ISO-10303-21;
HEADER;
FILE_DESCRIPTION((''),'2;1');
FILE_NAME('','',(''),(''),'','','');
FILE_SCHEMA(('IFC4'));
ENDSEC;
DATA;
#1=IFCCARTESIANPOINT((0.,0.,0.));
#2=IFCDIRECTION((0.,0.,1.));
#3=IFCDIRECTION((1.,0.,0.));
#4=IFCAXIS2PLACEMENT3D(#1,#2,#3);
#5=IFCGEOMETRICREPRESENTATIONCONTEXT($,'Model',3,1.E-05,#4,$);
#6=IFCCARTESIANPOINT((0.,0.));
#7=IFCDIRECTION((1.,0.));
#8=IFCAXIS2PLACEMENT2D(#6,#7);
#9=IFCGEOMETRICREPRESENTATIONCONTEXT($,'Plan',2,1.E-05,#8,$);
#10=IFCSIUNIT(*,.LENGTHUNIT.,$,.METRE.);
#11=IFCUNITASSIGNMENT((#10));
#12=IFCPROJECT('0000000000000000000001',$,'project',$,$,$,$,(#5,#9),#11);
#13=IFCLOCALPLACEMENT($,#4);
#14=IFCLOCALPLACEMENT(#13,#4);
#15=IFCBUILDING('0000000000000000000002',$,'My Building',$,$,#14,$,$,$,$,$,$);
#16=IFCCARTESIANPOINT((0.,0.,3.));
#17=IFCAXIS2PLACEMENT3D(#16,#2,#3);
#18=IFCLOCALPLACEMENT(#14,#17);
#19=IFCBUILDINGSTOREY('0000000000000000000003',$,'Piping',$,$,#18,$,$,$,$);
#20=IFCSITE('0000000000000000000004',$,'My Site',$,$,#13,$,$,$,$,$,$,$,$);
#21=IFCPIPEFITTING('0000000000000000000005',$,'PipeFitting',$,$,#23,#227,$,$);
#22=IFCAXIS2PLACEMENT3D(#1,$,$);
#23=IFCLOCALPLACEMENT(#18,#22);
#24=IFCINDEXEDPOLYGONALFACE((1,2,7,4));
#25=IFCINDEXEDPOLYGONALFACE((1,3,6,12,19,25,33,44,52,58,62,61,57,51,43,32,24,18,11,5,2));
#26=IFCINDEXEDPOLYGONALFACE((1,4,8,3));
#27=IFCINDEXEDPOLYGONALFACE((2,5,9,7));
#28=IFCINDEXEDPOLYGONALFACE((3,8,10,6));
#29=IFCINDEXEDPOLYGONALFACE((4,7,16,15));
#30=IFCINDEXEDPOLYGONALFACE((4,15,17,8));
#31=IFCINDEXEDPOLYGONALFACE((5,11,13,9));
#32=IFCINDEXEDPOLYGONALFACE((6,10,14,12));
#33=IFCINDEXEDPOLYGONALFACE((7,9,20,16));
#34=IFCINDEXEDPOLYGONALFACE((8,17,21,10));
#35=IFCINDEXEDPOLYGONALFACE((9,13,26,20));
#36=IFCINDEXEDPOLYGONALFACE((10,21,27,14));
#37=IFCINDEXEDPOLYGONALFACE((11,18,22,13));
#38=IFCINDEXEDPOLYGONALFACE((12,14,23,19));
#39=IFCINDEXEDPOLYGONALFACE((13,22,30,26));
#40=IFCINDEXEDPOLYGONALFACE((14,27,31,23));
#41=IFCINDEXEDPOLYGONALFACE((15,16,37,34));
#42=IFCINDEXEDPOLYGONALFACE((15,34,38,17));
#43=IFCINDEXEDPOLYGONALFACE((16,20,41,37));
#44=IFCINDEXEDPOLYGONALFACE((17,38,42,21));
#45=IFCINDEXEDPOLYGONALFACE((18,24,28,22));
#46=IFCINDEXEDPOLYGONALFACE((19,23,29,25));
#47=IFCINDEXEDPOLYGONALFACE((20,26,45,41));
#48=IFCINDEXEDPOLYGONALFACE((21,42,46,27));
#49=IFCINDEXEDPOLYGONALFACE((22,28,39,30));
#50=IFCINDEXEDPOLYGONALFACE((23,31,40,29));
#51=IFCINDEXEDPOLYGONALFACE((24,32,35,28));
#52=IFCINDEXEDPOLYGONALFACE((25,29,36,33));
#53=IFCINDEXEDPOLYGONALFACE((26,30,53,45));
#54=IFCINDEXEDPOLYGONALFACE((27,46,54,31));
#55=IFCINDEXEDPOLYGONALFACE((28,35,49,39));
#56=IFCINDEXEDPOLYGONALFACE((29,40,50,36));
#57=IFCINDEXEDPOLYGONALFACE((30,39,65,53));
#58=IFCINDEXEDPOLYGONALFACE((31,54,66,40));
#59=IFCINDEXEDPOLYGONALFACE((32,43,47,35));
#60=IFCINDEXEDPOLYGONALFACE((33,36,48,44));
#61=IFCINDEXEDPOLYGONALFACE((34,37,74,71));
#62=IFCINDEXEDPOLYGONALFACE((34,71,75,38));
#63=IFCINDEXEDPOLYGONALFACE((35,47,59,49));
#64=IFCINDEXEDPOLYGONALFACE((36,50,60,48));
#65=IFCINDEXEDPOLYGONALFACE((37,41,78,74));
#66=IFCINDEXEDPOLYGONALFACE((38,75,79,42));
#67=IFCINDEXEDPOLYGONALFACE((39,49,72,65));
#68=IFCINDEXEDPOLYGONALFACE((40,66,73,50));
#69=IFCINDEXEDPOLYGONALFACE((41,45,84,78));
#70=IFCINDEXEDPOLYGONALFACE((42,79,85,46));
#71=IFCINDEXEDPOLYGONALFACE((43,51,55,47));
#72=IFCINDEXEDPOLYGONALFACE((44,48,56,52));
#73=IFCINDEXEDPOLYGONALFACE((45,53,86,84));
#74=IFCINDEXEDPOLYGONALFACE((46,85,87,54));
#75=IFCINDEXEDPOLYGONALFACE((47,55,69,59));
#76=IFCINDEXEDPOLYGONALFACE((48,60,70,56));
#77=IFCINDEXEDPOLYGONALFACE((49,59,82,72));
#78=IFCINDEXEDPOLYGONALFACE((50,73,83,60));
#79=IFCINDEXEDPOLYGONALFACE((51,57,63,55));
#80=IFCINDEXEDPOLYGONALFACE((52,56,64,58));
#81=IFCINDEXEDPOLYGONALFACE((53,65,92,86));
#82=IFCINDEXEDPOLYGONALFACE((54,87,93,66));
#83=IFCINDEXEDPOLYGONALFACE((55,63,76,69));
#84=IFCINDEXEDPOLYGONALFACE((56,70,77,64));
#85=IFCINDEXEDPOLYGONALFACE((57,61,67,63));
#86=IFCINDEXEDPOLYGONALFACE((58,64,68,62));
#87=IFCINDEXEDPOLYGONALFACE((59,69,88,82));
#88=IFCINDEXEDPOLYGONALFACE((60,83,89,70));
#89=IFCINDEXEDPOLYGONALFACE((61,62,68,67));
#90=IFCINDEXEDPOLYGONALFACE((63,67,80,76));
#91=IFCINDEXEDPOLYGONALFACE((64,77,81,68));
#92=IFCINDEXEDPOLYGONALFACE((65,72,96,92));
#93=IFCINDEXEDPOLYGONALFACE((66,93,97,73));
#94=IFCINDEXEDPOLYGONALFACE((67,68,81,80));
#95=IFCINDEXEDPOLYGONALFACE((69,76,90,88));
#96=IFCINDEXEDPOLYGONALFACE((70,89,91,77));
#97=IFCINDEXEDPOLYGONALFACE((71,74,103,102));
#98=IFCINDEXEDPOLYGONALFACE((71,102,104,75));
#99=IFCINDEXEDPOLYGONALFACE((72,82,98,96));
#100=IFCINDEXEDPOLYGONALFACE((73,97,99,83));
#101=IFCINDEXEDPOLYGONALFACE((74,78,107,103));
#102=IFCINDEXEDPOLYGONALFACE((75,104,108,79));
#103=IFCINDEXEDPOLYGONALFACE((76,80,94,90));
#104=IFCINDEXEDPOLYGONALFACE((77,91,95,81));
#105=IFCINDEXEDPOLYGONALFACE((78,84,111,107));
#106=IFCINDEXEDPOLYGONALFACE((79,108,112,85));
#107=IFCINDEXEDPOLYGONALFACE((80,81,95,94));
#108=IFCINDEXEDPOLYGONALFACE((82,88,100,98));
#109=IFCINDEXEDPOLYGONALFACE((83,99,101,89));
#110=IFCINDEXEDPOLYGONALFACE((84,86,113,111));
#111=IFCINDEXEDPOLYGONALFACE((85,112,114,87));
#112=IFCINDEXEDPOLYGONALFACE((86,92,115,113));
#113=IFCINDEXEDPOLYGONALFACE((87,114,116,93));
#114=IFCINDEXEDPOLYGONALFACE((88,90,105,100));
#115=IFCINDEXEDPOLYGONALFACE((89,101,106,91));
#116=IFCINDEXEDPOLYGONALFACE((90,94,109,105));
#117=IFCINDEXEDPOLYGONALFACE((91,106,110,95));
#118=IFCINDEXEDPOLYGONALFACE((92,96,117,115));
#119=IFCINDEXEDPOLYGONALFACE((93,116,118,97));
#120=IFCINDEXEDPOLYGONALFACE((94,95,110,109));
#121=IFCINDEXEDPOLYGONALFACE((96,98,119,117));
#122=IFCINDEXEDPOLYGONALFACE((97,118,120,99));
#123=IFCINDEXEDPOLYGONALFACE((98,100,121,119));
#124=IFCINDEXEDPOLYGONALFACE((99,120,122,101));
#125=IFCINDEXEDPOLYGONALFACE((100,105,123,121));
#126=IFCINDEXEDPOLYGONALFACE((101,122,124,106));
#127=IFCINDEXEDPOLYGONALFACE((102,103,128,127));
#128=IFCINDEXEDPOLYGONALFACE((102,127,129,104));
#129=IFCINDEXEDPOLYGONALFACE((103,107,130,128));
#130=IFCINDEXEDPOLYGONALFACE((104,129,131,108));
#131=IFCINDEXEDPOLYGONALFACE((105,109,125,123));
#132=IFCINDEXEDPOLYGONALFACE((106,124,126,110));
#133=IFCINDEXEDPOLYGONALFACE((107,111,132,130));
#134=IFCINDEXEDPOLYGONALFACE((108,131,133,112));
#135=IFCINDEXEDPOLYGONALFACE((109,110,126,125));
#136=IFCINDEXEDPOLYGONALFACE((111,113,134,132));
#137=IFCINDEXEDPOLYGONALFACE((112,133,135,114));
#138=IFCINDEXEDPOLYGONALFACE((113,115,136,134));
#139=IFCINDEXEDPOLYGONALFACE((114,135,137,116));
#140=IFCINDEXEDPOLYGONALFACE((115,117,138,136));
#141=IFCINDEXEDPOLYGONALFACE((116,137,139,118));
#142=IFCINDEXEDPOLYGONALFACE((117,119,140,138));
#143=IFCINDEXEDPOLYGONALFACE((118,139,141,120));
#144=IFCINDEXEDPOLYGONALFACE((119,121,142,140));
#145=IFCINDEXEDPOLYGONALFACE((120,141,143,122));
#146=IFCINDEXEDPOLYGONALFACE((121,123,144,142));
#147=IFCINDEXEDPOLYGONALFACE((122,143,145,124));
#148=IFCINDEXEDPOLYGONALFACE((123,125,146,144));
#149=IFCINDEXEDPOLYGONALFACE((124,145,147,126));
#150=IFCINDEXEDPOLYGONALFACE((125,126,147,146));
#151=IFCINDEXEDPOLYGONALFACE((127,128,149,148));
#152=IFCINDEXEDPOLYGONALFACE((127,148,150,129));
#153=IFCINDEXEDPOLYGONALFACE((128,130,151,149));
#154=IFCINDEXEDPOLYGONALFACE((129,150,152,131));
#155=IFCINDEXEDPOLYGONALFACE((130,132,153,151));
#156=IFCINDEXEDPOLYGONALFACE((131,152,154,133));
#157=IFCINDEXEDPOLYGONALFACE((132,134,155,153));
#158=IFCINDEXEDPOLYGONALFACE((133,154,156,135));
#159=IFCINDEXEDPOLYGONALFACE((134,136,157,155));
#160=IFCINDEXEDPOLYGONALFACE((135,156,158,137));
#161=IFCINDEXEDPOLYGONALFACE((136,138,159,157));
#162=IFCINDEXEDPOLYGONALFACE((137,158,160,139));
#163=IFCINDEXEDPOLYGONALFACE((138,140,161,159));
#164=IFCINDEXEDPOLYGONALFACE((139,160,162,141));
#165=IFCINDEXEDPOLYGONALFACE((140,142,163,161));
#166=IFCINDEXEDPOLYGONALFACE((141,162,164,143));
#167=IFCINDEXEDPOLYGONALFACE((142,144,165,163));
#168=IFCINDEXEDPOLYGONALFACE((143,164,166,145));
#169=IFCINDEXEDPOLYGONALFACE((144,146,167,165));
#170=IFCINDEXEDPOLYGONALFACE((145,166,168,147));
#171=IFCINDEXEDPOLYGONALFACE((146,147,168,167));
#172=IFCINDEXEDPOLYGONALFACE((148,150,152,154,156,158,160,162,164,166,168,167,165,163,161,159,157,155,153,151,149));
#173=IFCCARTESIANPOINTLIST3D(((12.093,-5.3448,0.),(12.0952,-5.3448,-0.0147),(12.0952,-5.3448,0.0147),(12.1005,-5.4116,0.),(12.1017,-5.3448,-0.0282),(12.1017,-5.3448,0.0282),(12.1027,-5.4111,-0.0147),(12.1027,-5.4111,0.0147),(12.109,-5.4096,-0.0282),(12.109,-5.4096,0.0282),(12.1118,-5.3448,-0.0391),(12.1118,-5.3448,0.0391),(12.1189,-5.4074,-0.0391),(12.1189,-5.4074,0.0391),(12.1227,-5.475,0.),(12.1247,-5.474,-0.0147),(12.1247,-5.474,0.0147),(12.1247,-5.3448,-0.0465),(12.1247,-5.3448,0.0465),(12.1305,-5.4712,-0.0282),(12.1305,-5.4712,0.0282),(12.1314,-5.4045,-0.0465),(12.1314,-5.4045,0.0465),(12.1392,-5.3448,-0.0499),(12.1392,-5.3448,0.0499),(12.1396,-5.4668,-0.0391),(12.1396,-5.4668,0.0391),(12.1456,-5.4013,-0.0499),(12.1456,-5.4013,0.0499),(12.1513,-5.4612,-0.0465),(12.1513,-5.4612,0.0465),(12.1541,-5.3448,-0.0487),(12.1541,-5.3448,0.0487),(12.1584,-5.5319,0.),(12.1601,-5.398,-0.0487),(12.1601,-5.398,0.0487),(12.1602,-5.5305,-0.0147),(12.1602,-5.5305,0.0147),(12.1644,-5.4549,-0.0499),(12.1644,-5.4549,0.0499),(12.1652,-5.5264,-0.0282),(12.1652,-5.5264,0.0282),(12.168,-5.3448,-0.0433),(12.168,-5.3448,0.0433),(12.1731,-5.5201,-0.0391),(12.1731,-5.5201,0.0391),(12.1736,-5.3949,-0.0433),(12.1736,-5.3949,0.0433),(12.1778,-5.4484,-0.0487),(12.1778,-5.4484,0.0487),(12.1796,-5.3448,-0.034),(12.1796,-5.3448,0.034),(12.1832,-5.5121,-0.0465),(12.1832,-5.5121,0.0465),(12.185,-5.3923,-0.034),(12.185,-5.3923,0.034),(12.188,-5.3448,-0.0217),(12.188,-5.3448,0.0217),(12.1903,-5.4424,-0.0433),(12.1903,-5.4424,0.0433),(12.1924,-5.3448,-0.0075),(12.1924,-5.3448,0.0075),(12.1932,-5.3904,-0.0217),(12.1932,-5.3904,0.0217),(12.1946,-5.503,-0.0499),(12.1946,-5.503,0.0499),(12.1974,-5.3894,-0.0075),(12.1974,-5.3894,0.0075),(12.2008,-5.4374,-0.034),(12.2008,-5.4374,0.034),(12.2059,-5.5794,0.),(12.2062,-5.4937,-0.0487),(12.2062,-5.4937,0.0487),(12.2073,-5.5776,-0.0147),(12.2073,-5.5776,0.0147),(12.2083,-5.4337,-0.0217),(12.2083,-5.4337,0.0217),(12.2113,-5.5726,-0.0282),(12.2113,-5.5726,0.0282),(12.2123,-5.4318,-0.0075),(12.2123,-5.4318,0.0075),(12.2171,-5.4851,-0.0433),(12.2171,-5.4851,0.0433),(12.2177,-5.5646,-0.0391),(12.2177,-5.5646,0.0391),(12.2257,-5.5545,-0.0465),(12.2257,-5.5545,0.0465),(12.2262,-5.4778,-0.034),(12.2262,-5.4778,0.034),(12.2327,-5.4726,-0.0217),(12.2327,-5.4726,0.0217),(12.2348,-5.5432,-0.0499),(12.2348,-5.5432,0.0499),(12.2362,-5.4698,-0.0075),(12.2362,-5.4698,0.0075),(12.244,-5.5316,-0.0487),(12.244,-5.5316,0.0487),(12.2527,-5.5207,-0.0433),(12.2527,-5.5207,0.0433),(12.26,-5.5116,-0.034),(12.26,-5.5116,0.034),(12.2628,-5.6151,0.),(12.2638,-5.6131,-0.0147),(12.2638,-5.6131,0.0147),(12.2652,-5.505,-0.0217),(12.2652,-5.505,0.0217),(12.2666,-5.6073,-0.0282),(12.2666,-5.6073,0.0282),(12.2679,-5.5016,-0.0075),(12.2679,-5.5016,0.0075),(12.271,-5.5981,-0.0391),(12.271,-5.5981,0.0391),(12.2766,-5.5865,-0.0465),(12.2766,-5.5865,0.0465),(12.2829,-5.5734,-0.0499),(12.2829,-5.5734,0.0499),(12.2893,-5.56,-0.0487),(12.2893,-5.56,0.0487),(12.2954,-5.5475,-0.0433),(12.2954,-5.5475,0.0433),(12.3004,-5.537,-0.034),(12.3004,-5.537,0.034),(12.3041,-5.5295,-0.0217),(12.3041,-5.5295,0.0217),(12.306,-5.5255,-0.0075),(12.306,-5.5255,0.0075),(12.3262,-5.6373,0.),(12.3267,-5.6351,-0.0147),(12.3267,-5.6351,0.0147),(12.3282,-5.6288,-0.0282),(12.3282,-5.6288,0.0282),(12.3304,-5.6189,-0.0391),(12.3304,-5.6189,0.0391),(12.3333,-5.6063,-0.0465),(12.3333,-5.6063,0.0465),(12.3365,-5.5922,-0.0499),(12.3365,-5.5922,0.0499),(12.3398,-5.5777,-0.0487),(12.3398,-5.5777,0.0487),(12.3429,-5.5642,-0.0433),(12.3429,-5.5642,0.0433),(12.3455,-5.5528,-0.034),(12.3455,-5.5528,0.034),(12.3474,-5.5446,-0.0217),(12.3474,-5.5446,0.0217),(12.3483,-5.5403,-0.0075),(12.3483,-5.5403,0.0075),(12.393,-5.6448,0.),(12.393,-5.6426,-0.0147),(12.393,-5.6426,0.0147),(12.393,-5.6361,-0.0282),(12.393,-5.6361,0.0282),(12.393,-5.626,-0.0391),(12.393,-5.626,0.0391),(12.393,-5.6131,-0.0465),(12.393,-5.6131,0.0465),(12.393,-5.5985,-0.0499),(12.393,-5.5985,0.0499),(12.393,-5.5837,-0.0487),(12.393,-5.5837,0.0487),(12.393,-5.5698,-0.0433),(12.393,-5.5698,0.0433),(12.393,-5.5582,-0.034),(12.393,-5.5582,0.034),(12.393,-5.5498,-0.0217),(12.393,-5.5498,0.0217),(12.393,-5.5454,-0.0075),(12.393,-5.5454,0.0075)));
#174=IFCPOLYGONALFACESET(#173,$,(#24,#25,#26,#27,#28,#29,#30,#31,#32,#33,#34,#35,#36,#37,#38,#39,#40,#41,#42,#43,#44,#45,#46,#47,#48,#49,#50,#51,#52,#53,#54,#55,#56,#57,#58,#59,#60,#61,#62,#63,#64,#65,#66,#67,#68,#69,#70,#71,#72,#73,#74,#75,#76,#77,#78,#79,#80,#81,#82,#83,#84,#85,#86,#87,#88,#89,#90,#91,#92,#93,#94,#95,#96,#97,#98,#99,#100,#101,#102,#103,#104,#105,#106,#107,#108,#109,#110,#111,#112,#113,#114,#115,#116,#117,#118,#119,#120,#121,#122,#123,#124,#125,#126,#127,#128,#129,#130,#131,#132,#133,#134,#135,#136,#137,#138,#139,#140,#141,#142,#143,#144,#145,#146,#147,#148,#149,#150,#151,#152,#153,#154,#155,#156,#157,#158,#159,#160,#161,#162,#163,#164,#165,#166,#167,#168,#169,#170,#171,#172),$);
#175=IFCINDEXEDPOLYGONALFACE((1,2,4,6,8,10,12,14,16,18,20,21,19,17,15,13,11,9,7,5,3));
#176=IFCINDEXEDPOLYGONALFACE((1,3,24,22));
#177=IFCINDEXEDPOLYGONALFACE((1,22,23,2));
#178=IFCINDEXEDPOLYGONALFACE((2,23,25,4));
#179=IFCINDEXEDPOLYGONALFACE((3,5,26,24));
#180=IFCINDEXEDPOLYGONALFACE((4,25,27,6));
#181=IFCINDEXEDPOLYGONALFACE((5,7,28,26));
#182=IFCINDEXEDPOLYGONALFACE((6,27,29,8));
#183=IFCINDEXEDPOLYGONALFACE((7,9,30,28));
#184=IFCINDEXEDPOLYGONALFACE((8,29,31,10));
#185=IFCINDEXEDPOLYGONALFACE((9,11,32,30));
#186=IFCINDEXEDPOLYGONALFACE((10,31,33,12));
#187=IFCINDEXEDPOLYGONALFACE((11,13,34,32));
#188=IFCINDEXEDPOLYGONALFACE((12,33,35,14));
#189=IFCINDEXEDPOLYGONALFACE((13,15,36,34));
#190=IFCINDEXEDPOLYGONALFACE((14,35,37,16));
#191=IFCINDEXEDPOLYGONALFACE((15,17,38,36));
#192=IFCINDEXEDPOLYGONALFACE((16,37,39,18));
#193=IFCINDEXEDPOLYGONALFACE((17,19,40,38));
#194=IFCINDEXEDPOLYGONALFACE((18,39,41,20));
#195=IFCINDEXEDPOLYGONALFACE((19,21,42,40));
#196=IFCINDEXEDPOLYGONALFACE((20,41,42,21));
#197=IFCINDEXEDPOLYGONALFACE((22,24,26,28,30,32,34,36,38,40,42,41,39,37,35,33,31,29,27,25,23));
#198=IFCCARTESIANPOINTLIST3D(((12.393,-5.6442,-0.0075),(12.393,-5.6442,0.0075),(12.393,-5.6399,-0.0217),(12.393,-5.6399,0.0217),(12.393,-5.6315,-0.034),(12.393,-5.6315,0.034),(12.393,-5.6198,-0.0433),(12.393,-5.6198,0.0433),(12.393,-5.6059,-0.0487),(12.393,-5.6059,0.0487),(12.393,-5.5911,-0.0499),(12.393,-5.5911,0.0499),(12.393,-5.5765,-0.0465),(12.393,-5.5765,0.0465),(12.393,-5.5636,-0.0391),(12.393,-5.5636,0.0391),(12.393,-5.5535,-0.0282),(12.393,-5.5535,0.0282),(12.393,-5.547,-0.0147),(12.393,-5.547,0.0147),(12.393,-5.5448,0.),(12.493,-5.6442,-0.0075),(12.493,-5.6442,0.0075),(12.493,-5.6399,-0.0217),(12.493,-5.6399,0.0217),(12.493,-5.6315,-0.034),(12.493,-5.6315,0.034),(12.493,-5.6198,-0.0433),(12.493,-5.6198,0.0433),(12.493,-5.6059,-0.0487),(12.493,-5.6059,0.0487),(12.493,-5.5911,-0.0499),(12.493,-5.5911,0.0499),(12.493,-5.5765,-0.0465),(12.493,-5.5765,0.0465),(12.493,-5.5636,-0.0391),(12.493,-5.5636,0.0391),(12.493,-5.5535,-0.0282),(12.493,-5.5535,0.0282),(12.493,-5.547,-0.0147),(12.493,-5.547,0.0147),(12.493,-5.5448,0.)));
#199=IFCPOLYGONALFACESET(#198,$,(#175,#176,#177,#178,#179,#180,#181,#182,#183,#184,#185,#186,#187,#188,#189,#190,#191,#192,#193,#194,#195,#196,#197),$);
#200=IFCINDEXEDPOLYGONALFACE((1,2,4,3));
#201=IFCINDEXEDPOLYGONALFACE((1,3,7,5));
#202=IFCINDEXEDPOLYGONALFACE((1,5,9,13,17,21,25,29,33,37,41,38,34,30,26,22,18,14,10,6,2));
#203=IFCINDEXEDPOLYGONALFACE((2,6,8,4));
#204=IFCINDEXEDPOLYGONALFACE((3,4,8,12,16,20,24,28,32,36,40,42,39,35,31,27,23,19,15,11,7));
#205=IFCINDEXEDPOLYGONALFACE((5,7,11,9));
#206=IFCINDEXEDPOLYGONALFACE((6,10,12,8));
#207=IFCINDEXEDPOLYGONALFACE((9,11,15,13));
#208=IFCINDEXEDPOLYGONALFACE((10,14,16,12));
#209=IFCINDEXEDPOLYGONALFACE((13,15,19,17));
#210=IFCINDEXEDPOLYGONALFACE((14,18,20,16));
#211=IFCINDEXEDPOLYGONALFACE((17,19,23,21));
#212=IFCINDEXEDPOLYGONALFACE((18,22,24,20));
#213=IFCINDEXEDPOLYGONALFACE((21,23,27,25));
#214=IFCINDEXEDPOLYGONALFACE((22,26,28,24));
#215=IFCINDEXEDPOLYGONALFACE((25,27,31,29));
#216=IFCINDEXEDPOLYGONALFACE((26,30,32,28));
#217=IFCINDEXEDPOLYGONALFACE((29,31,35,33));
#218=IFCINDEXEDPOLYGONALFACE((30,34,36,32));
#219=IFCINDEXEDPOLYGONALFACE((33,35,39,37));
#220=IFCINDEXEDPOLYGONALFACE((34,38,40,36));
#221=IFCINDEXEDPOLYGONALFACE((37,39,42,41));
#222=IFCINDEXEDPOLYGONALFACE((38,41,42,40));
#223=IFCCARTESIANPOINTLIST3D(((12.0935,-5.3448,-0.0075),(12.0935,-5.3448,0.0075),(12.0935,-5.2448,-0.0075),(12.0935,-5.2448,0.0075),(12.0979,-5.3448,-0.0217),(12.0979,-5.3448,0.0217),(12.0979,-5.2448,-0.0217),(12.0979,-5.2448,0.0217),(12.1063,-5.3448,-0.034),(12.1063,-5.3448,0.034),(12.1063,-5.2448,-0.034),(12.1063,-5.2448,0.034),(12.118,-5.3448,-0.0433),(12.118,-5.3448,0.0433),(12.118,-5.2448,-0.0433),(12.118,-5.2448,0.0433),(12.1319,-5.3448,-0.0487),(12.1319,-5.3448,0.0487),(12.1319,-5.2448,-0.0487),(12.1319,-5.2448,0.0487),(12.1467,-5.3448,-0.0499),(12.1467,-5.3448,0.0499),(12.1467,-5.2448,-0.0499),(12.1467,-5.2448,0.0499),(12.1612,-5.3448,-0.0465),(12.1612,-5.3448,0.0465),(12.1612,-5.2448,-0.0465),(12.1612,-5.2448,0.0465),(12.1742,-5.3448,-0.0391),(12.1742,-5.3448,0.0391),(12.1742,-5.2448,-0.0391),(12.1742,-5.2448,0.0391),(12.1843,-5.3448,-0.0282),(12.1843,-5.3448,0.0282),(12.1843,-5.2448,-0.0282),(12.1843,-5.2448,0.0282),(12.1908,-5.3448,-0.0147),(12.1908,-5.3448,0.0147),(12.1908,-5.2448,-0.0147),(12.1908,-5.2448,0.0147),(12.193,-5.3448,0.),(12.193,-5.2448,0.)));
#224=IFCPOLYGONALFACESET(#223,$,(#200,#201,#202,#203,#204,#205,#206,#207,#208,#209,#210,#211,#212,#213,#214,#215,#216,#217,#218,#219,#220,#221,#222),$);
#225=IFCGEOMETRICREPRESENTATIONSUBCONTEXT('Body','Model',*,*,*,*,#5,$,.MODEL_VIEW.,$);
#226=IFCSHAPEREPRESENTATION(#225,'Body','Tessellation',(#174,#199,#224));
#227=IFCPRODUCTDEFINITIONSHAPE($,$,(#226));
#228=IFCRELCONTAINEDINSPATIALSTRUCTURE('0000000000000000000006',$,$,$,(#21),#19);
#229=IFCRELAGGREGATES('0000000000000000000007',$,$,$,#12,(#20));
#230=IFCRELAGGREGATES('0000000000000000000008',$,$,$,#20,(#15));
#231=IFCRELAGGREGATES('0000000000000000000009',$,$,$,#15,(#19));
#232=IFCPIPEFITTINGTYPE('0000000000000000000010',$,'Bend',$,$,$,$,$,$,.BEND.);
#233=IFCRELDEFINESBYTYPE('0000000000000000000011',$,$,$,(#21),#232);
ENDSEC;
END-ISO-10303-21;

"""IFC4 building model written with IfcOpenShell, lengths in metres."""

from ifc_helpers import new_model, entity, si_unit, frame, origin_with_axes, origin_2d_with_axis, place, context, subcontext, project, spatial, circle, extrude, source, transform, mapped, type_object, type_shapes, element, save


model = new_model("IFC4")

# Units and contexts
model_context = context("Model", 3, precision=1e-05, world=origin_with_axes())
plan_context = context("Plan", 2, precision=1e-05, world=origin_2d_with_axis())
body_context = subcontext(model_context, "Body", "Model", "MODEL_VIEW")
ifc_project = project(units=[si_unit("LENGTHUNIT", "METRE")], contexts=[model_context, plan_context])

# Site, building, storey
site_placement = place(None, origin_with_axes())
site = spatial("IfcSite", under=ifc_project, at=site_placement, Name="My Site")
building_placement = place(site_placement, origin_with_axes())
building = spatial("IfcBuilding", under=site, at=building_placement, Name="My Building")
storey_placement = place(building_placement, frame((0.0, 0.0, 3.0), z_axis=(0.0, 0.0, 1.0), x_axis=(1.0, 0.0, 0.0)))
storey = spatial("IfcBuildingStorey", under=building, at=storey_placement, Name="Piping")

# Pipe fitting
pipe_fitting_type_1 = type_object("IfcPipeFittingType", Name="Bend", PredefinedType="BEND")
shared_shape_1 = source(origin_with_axes(), body_context, "Body", "SolidModel", [
    entity("IfcSweptDiskSolid", entity("IfcIndexedPolyCurve", entity("IfcCartesianPointList3D", [[0.0, 0.0, -0.1], [0.0732, 0.0, -0.2768], [0.25, 0.0, -0.35]]), [entity("IfcArcIndex", [1, 2, 3])]), 0.05),
    extrude(circle(Radius=0.05), origin_with_axes(), (0.0, 0.0, -1.0), 0.1),
    extrude(circle(Radius=0.05), frame((0.25, 0.0, -0.35), z_axis=(1.0, 0.0, 0.0), x_axis=(0.0, 0.0, 1.0)), (0.0, 0.0, 1.0), 0.1),
])
type_shapes(pipe_fitting_type_1, [shared_shape_1])
for number, where, z_axis, x_axis, name in (
    (1, (12.493, -5.5948, 0.0), (1.0, 0.0, 0.0), (0.0, 1.0, 0.0), "PipeFitting"),
):
    element("IfcPipeFitting", number, at=place(storey_placement, frame(where, z_axis=z_axis, x_axis=x_axis)), inside=storey, type_object=pipe_fitting_type_1, Name=name, context=body_context, shape_type="MappedRepresentation", body=[
        mapped(shared_shape_1, transform((0.0, 0.0, 0.0), x_axis=(1.0, 0.0, 0.0), y_axis=(0.0, 1.0, 0.0), z_axis=(0.0, 0.0, 1.0), scale=1.0)),
    ])

save(model, "model.ifc")
